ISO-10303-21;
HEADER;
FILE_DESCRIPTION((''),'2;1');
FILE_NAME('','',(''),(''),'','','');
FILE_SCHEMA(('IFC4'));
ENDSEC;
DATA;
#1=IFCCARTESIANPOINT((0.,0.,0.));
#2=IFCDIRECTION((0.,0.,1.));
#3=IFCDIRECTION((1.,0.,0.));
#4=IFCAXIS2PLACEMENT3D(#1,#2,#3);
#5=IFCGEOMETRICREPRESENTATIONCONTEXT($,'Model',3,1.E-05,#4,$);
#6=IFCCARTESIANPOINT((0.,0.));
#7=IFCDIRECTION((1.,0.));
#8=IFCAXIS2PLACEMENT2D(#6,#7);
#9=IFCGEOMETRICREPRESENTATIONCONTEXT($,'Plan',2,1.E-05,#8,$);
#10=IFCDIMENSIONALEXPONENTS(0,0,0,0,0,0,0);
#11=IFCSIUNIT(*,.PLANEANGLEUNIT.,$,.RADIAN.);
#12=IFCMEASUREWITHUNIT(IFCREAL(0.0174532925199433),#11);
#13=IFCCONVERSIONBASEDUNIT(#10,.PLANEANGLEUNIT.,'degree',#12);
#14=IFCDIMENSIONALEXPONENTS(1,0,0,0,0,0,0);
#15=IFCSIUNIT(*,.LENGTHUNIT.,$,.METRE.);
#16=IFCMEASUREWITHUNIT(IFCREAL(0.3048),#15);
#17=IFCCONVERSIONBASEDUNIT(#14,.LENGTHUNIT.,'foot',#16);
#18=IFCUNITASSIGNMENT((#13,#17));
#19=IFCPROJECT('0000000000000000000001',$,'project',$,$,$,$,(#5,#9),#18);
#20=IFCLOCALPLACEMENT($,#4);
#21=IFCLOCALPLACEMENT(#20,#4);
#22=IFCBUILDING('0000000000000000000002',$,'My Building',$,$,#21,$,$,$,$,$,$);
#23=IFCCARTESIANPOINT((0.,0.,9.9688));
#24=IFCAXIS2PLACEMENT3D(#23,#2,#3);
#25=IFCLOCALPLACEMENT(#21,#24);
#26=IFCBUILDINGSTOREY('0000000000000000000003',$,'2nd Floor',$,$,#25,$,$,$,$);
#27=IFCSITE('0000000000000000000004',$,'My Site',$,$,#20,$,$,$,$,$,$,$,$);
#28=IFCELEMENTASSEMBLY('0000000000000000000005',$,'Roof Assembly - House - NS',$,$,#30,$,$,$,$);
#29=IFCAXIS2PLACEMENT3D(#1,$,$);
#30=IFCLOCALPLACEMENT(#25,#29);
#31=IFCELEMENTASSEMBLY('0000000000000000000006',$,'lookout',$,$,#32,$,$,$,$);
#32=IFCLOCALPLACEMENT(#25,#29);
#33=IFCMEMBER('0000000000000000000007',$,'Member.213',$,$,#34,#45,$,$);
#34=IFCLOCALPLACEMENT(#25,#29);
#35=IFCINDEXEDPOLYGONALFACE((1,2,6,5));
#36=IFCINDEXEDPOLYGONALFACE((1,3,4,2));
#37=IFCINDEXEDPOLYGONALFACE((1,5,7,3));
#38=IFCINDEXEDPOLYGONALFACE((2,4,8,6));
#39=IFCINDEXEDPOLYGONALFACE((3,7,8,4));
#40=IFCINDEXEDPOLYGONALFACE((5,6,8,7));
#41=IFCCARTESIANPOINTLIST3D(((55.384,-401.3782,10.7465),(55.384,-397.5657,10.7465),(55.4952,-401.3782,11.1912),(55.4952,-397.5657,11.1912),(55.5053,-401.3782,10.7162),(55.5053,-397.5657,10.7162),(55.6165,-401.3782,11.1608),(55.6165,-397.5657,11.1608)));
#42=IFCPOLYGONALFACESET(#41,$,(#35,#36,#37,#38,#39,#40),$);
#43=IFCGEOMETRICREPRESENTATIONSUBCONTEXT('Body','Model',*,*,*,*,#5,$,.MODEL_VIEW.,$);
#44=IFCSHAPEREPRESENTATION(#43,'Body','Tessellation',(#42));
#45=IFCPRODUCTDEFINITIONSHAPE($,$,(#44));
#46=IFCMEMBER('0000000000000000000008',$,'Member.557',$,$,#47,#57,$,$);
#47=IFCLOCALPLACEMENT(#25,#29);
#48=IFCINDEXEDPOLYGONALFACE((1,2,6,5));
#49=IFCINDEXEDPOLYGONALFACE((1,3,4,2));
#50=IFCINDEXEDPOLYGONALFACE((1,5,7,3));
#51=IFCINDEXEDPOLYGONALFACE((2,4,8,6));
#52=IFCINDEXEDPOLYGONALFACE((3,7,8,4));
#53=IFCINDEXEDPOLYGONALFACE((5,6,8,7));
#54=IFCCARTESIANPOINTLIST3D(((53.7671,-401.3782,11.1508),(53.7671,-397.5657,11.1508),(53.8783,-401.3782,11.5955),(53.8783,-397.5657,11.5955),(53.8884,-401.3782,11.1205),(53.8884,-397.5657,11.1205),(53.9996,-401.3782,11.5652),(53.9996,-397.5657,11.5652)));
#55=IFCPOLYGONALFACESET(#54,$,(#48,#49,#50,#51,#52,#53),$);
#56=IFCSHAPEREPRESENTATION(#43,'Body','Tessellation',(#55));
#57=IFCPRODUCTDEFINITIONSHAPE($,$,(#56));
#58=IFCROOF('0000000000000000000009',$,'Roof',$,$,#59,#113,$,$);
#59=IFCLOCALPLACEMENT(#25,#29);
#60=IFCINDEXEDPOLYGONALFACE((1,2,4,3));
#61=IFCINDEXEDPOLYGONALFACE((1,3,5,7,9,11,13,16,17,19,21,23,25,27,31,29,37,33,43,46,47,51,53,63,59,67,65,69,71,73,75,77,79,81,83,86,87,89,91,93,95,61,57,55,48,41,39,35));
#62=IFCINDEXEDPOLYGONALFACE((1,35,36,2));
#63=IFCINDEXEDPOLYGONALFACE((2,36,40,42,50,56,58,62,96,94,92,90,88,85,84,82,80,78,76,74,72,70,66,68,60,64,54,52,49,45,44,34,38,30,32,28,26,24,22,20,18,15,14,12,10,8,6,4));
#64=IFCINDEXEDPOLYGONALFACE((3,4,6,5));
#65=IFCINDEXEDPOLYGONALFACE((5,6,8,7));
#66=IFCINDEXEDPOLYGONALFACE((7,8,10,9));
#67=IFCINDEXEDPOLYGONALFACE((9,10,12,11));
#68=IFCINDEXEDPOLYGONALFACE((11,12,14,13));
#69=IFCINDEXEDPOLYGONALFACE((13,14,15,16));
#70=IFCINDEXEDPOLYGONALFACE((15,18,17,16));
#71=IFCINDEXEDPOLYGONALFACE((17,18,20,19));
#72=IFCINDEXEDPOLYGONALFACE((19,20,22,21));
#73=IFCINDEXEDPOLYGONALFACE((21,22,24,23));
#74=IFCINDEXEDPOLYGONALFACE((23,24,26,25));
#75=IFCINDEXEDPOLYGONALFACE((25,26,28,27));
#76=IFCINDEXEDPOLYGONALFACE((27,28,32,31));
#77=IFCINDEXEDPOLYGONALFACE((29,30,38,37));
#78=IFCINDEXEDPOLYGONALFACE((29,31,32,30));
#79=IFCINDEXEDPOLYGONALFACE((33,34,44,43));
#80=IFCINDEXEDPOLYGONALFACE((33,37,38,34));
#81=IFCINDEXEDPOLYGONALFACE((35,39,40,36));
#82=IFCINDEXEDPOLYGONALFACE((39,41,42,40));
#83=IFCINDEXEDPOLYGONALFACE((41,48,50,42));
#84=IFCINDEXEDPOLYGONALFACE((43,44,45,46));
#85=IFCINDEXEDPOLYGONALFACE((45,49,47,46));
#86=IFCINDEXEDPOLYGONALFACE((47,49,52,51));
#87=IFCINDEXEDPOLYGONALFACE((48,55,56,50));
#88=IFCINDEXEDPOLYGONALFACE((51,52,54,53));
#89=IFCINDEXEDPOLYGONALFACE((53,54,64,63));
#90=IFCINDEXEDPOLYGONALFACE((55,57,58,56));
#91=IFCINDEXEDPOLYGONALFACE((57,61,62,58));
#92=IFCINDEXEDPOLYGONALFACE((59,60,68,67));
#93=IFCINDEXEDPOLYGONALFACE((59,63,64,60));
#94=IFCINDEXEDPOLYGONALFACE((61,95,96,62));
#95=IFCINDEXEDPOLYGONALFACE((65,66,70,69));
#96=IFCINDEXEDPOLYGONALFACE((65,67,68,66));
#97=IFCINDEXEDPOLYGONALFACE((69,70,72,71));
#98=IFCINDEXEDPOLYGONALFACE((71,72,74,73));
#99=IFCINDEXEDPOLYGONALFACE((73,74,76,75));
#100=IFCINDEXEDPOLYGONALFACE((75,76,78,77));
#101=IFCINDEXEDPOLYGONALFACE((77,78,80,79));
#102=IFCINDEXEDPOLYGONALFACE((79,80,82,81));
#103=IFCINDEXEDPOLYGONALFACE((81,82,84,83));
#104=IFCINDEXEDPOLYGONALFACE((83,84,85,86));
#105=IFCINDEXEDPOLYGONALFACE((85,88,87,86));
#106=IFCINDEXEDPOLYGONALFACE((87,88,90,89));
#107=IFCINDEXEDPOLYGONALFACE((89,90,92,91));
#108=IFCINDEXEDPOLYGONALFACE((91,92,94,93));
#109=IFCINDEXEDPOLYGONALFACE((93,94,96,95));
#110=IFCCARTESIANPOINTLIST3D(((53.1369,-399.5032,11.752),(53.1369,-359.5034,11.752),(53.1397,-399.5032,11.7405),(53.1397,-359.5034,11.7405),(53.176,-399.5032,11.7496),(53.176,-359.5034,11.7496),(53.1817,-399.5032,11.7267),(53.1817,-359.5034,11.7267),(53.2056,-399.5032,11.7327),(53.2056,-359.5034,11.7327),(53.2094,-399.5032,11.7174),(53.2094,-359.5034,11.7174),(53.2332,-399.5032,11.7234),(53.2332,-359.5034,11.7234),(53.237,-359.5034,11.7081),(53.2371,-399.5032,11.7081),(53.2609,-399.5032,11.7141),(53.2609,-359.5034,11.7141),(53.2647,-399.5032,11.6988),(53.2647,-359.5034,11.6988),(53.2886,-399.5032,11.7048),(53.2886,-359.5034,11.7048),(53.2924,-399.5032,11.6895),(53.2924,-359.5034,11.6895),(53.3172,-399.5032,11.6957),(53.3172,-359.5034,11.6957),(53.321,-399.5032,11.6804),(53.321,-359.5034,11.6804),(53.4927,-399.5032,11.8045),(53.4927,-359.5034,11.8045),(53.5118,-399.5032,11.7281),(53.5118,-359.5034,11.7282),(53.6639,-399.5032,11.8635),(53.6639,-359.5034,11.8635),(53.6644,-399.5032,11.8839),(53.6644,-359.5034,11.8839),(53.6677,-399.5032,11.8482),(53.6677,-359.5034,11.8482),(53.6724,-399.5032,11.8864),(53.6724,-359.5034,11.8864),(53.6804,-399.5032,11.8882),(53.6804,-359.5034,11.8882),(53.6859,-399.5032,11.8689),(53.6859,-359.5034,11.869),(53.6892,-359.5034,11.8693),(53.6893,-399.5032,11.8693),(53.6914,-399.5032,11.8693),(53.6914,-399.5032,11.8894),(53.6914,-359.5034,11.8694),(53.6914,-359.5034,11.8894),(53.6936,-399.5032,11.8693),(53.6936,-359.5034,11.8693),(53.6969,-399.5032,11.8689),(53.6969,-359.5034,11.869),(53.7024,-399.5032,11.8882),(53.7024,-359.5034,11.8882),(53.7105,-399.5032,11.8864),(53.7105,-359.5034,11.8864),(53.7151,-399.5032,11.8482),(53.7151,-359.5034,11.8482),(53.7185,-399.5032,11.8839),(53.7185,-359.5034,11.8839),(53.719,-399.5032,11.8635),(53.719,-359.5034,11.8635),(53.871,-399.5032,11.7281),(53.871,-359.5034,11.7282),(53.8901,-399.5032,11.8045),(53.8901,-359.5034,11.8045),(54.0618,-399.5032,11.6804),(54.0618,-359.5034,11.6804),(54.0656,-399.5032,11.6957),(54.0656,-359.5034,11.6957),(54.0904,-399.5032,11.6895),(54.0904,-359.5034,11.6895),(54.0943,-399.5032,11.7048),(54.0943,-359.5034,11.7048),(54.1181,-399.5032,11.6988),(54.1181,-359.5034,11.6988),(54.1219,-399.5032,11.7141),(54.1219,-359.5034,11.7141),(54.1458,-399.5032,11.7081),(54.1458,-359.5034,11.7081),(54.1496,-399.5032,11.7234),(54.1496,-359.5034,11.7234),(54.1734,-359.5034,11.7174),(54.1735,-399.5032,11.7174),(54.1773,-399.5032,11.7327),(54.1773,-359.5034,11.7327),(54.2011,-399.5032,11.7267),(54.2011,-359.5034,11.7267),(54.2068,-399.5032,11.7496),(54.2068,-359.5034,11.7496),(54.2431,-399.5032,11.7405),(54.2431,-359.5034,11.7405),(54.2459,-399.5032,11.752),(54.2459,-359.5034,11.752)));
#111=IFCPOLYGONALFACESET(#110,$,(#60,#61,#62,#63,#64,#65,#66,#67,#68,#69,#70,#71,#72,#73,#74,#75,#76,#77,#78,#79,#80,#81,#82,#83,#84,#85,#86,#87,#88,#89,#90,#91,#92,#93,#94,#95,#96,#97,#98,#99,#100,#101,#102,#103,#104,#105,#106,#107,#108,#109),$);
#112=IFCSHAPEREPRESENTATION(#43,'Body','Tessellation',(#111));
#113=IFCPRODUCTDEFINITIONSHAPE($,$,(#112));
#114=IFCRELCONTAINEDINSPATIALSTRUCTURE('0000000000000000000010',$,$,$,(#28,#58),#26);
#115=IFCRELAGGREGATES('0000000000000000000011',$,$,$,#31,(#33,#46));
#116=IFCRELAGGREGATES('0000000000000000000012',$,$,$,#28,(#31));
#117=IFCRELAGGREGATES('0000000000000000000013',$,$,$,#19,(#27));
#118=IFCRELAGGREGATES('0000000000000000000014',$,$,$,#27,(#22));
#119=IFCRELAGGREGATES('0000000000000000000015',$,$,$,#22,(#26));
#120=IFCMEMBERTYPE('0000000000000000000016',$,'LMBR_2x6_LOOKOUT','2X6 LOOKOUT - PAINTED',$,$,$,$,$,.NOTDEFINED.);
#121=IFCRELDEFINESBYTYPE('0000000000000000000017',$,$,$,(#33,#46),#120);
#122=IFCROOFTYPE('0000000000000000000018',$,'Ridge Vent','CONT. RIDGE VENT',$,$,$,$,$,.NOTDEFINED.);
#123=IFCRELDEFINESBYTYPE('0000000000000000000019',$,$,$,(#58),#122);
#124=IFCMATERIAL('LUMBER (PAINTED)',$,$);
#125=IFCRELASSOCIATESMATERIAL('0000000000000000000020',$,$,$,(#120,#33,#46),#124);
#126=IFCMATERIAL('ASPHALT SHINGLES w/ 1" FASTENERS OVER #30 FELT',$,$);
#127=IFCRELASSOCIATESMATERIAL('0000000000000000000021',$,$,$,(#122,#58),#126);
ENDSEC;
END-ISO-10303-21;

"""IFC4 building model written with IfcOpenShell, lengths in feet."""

from ifc_helpers import new_model, entity, si_unit, converted_unit, frame, origin_with_axes, origin_2d_with_axis, place, context, subcontext, project, spatial, indexed_curve, outline, extrude, material, material_profile, profile_set, profile_usage, type_object, element, aggregate, save


model = new_model("IFC4")

# Units and contexts
model_context = context("Model", 3, precision=1e-05, world=origin_with_axes())
plan_context = context("Plan", 2, precision=1e-05, world=origin_2d_with_axis())
body_context = subcontext(model_context, "Body", "Model", "MODEL_VIEW")
ifc_project = project(units=[converted_unit("PLANEANGLEUNIT", "degree", entity("IfcReal", 0.0174532925199433), si_unit("PLANEANGLEUNIT", "RADIAN"), dimensions=[0, 0, 0, 0, 0, 0, 0]), converted_unit("LENGTHUNIT", "foot", entity("IfcReal", 0.3048), si_unit("LENGTHUNIT", "METRE"), dimensions=[1, 0, 0, 0, 0, 0, 0])], contexts=[model_context, plan_context])

# Site, building, storey
site_placement = place(None, origin_with_axes())
site = spatial("IfcSite", under=ifc_project, at=site_placement, Name="My Site")
building_placement = place(site_placement, origin_with_axes())
building = spatial("IfcBuilding", under=site, at=building_placement, Name="My Building")
storey_placement = place(building_placement, frame((0.0, 0.0, 9.9688), z_axis=(0.0, 0.0, 1.0), x_axis=(1.0, 0.0, 0.0)))
storey = spatial("IfcBuildingStorey", under=building, at=storey_placement, Name="2nd Floor")

# Element assemblies, members
assembly_1_placement = place(storey_placement, frame((0.0, 0.0, -9.9688), z_axis=(0.0, 0.0, 1.0), x_axis=(1.0, 0.0, 0.0)))
assembly_1 = element("IfcElementAssembly", 1, at=assembly_1_placement, inside=storey, Name="Roof Assembly - House - NS")
ifc_material_1 = material(Name="LUMBER (PAINTED)")
assembly_2_placement = place(assembly_1_placement, frame((53.6914, -397.5032, 21.6754), z_axis=(0.0, 0.0, 1.0), x_axis=(-1.0, 0.0, 0.0)))
assembly_2 = element("IfcElementAssembly", 2, at=assembly_2_placement, Name="lookout")
ifc_material_profile_1 = material_profile(ifc_material_1, outline(indexed_curve([(-0.0625, 0.2292), (0.0625, 0.2292), (0.0625, -0.2292), (-0.0625, -0.2292), (-0.0625, 0.2292)])))
ifc_profile_set_1 = profile_set([ifc_material_profile_1])
ifc_profile_usage_1 = profile_usage(ifc_profile_set_1)
member_type_1 = type_object("IfcMemberType", Name="LMBR_2x6_LOOKOUT", Description="2X6 LOOKOUT - PAINTED", PredefinedType="NOTDEFINED", material=ifc_profile_set_1)
member_1_placement = place(assembly_2_placement, frame((-1.8089, 0.0625, -0.753), z_axis=(0.0, 1.0, 0.0), x_axis=(-0.970127, 0.0, -0.242599)))
member_1 = element("IfcMember", 3, at=member_1_placement, type_object=member_type_1, material=ifc_profile_usage_1, Name="Member.213", context=body_context, shape_type="SweptSolid", body=[
    extrude(outline(indexed_curve([(-0.0625, 0.2292), (0.0625, 0.2292), (0.0625, -0.2292), (-0.0625, -0.2292), (-0.0625, 0.2292)])), origin_with_axes(), (0.0, 0.0, 1.0), 3.8125),
])
ifc_profile_usage_2 = profile_usage(ifc_profile_set_1)
member_2_placement = place(assembly_2_placement, frame((-0.192, 0.0625, -0.3487), z_axis=(0.0, 1.0, 0.0), x_axis=(-0.970127, 0.0, -0.242599)))
member_2 = element("IfcMember", 4, at=member_2_placement, type_object=member_type_1, material=ifc_profile_usage_2, Name="Member.557", context=body_context, shape_type="SweptSolid", body=[
    extrude(outline(indexed_curve([(-0.0625, 0.2292), (0.0625, 0.2292), (0.0625, -0.2292), (-0.0625, -0.2292), (-0.0625, 0.2292)])), origin_with_axes(), (0.0, 0.0, 1.0), 3.8125),
])
aggregate(assembly_2, [member_1, member_2])
ifc_material_2 = material(Name="ASPHALT SHINGLES w/ 1\" FASTENERS OVER #30 FELT")
aggregate(assembly_1, [assembly_2])

# Roof
ifc_material_profile_2 = material_profile(ifc_material_2, outline(indexed_curve([(-0.0055, -0.0205), (-0.0022, -0.0202), (0.0, -0.0201), (0.0022, -0.0202), (0.0055, -0.0205), (0.0275, -0.0259), (0.0237, -0.0412), (0.1987, -0.085), (0.1796, -0.1613), (0.3704, -0.209), (0.3742, -0.1937), (0.399, -0.1999), (0.4028, -0.1847), (0.4267, -0.1906), (0.4305, -0.1754), (0.4544, -0.1813), (0.4582, -0.1661), (0.482, -0.172), (0.4859, -0.1568), (0.5097, -0.1627), (0.5154, -0.1398), (0.5517, -0.1489), (0.5545, -0.1374), (0.027, -0.0055), (0.0191, -0.003), (0.011, -0.0013), (0.0, 0.0), (-0.011, -0.0013), (-0.019, -0.003), (-0.027, -0.0055), (-0.5545, -0.1374), (-0.5517, -0.1489), (-0.5154, -0.1398), (-0.5097, -0.1627), (-0.4859, -0.1568), (-0.482, -0.172), (-0.4582, -0.1661), (-0.4544, -0.1813), (-0.4305, -0.1754), (-0.4267, -0.1906), (-0.4028, -0.1847), (-0.399, -0.1999), (-0.3742, -0.1937), (-0.3704, -0.209), (-0.1796, -0.1613), (-0.1987, -0.085), (-0.0237, -0.0412), (-0.0275, -0.0259), (-0.0055, -0.0205)])))
ifc_profile_set_2 = profile_set([ifc_material_profile_2])
ifc_profile_usage_3 = profile_usage(ifc_profile_set_2, cardinal=5)
roof_type_1 = type_object("IfcRoofType", Name="Ridge Vent", Description="CONT. RIDGE VENT", PredefinedType="NOTDEFINED", material=ifc_profile_set_2)
roof_1_placement = place(storey_placement, frame((53.6914, -399.5032, 11.8894), z_axis=(0.0, 1.0, 0.0), x_axis=(-1.0, 0.0, 0.0)))
element("IfcRoof", 5, at=roof_1_placement, inside=storey, type_object=roof_type_1, material=ifc_profile_usage_3, Name="Roof", context=body_context, shape_type="SweptSolid", body=[
    extrude(outline(indexed_curve([(-0.0055, -0.0205), (-0.0022, -0.0202), (0.0, -0.0201), (0.0022, -0.0202), (0.0055, -0.0205), (0.0275, -0.0259), (0.0237, -0.0412), (0.1987, -0.085), (0.1796, -0.1613), (0.3704, -0.209), (0.3742, -0.1937), (0.399, -0.1999), (0.4028, -0.1847), (0.4267, -0.1906), (0.4305, -0.1754), (0.4544, -0.1813), (0.4582, -0.1661), (0.482, -0.172), (0.4859, -0.1568), (0.5097, -0.1627), (0.5154, -0.1398), (0.5517, -0.1489), (0.5545, -0.1374), (0.027, -0.0055), (0.0191, -0.003), (0.011, -0.0013), (0.0, 0.0), (-0.011, -0.0013), (-0.019, -0.003), (-0.027, -0.0055), (-0.5545, -0.1374), (-0.5517, -0.1489), (-0.5154, -0.1398), (-0.5097, -0.1627), (-0.4859, -0.1568), (-0.482, -0.172), (-0.4582, -0.1661), (-0.4544, -0.1813), (-0.4305, -0.1754), (-0.4267, -0.1906), (-0.4028, -0.1847), (-0.399, -0.1999), (-0.3742, -0.1937), (-0.3704, -0.209), (-0.1796, -0.1613), (-0.1987, -0.085), (-0.0237, -0.0412), (-0.0275, -0.0259), (-0.0055, -0.0205)])), origin_with_axes(), (0.0, 0.0, 1.0), 39.9998),
])

save(model, "model.ifc")
